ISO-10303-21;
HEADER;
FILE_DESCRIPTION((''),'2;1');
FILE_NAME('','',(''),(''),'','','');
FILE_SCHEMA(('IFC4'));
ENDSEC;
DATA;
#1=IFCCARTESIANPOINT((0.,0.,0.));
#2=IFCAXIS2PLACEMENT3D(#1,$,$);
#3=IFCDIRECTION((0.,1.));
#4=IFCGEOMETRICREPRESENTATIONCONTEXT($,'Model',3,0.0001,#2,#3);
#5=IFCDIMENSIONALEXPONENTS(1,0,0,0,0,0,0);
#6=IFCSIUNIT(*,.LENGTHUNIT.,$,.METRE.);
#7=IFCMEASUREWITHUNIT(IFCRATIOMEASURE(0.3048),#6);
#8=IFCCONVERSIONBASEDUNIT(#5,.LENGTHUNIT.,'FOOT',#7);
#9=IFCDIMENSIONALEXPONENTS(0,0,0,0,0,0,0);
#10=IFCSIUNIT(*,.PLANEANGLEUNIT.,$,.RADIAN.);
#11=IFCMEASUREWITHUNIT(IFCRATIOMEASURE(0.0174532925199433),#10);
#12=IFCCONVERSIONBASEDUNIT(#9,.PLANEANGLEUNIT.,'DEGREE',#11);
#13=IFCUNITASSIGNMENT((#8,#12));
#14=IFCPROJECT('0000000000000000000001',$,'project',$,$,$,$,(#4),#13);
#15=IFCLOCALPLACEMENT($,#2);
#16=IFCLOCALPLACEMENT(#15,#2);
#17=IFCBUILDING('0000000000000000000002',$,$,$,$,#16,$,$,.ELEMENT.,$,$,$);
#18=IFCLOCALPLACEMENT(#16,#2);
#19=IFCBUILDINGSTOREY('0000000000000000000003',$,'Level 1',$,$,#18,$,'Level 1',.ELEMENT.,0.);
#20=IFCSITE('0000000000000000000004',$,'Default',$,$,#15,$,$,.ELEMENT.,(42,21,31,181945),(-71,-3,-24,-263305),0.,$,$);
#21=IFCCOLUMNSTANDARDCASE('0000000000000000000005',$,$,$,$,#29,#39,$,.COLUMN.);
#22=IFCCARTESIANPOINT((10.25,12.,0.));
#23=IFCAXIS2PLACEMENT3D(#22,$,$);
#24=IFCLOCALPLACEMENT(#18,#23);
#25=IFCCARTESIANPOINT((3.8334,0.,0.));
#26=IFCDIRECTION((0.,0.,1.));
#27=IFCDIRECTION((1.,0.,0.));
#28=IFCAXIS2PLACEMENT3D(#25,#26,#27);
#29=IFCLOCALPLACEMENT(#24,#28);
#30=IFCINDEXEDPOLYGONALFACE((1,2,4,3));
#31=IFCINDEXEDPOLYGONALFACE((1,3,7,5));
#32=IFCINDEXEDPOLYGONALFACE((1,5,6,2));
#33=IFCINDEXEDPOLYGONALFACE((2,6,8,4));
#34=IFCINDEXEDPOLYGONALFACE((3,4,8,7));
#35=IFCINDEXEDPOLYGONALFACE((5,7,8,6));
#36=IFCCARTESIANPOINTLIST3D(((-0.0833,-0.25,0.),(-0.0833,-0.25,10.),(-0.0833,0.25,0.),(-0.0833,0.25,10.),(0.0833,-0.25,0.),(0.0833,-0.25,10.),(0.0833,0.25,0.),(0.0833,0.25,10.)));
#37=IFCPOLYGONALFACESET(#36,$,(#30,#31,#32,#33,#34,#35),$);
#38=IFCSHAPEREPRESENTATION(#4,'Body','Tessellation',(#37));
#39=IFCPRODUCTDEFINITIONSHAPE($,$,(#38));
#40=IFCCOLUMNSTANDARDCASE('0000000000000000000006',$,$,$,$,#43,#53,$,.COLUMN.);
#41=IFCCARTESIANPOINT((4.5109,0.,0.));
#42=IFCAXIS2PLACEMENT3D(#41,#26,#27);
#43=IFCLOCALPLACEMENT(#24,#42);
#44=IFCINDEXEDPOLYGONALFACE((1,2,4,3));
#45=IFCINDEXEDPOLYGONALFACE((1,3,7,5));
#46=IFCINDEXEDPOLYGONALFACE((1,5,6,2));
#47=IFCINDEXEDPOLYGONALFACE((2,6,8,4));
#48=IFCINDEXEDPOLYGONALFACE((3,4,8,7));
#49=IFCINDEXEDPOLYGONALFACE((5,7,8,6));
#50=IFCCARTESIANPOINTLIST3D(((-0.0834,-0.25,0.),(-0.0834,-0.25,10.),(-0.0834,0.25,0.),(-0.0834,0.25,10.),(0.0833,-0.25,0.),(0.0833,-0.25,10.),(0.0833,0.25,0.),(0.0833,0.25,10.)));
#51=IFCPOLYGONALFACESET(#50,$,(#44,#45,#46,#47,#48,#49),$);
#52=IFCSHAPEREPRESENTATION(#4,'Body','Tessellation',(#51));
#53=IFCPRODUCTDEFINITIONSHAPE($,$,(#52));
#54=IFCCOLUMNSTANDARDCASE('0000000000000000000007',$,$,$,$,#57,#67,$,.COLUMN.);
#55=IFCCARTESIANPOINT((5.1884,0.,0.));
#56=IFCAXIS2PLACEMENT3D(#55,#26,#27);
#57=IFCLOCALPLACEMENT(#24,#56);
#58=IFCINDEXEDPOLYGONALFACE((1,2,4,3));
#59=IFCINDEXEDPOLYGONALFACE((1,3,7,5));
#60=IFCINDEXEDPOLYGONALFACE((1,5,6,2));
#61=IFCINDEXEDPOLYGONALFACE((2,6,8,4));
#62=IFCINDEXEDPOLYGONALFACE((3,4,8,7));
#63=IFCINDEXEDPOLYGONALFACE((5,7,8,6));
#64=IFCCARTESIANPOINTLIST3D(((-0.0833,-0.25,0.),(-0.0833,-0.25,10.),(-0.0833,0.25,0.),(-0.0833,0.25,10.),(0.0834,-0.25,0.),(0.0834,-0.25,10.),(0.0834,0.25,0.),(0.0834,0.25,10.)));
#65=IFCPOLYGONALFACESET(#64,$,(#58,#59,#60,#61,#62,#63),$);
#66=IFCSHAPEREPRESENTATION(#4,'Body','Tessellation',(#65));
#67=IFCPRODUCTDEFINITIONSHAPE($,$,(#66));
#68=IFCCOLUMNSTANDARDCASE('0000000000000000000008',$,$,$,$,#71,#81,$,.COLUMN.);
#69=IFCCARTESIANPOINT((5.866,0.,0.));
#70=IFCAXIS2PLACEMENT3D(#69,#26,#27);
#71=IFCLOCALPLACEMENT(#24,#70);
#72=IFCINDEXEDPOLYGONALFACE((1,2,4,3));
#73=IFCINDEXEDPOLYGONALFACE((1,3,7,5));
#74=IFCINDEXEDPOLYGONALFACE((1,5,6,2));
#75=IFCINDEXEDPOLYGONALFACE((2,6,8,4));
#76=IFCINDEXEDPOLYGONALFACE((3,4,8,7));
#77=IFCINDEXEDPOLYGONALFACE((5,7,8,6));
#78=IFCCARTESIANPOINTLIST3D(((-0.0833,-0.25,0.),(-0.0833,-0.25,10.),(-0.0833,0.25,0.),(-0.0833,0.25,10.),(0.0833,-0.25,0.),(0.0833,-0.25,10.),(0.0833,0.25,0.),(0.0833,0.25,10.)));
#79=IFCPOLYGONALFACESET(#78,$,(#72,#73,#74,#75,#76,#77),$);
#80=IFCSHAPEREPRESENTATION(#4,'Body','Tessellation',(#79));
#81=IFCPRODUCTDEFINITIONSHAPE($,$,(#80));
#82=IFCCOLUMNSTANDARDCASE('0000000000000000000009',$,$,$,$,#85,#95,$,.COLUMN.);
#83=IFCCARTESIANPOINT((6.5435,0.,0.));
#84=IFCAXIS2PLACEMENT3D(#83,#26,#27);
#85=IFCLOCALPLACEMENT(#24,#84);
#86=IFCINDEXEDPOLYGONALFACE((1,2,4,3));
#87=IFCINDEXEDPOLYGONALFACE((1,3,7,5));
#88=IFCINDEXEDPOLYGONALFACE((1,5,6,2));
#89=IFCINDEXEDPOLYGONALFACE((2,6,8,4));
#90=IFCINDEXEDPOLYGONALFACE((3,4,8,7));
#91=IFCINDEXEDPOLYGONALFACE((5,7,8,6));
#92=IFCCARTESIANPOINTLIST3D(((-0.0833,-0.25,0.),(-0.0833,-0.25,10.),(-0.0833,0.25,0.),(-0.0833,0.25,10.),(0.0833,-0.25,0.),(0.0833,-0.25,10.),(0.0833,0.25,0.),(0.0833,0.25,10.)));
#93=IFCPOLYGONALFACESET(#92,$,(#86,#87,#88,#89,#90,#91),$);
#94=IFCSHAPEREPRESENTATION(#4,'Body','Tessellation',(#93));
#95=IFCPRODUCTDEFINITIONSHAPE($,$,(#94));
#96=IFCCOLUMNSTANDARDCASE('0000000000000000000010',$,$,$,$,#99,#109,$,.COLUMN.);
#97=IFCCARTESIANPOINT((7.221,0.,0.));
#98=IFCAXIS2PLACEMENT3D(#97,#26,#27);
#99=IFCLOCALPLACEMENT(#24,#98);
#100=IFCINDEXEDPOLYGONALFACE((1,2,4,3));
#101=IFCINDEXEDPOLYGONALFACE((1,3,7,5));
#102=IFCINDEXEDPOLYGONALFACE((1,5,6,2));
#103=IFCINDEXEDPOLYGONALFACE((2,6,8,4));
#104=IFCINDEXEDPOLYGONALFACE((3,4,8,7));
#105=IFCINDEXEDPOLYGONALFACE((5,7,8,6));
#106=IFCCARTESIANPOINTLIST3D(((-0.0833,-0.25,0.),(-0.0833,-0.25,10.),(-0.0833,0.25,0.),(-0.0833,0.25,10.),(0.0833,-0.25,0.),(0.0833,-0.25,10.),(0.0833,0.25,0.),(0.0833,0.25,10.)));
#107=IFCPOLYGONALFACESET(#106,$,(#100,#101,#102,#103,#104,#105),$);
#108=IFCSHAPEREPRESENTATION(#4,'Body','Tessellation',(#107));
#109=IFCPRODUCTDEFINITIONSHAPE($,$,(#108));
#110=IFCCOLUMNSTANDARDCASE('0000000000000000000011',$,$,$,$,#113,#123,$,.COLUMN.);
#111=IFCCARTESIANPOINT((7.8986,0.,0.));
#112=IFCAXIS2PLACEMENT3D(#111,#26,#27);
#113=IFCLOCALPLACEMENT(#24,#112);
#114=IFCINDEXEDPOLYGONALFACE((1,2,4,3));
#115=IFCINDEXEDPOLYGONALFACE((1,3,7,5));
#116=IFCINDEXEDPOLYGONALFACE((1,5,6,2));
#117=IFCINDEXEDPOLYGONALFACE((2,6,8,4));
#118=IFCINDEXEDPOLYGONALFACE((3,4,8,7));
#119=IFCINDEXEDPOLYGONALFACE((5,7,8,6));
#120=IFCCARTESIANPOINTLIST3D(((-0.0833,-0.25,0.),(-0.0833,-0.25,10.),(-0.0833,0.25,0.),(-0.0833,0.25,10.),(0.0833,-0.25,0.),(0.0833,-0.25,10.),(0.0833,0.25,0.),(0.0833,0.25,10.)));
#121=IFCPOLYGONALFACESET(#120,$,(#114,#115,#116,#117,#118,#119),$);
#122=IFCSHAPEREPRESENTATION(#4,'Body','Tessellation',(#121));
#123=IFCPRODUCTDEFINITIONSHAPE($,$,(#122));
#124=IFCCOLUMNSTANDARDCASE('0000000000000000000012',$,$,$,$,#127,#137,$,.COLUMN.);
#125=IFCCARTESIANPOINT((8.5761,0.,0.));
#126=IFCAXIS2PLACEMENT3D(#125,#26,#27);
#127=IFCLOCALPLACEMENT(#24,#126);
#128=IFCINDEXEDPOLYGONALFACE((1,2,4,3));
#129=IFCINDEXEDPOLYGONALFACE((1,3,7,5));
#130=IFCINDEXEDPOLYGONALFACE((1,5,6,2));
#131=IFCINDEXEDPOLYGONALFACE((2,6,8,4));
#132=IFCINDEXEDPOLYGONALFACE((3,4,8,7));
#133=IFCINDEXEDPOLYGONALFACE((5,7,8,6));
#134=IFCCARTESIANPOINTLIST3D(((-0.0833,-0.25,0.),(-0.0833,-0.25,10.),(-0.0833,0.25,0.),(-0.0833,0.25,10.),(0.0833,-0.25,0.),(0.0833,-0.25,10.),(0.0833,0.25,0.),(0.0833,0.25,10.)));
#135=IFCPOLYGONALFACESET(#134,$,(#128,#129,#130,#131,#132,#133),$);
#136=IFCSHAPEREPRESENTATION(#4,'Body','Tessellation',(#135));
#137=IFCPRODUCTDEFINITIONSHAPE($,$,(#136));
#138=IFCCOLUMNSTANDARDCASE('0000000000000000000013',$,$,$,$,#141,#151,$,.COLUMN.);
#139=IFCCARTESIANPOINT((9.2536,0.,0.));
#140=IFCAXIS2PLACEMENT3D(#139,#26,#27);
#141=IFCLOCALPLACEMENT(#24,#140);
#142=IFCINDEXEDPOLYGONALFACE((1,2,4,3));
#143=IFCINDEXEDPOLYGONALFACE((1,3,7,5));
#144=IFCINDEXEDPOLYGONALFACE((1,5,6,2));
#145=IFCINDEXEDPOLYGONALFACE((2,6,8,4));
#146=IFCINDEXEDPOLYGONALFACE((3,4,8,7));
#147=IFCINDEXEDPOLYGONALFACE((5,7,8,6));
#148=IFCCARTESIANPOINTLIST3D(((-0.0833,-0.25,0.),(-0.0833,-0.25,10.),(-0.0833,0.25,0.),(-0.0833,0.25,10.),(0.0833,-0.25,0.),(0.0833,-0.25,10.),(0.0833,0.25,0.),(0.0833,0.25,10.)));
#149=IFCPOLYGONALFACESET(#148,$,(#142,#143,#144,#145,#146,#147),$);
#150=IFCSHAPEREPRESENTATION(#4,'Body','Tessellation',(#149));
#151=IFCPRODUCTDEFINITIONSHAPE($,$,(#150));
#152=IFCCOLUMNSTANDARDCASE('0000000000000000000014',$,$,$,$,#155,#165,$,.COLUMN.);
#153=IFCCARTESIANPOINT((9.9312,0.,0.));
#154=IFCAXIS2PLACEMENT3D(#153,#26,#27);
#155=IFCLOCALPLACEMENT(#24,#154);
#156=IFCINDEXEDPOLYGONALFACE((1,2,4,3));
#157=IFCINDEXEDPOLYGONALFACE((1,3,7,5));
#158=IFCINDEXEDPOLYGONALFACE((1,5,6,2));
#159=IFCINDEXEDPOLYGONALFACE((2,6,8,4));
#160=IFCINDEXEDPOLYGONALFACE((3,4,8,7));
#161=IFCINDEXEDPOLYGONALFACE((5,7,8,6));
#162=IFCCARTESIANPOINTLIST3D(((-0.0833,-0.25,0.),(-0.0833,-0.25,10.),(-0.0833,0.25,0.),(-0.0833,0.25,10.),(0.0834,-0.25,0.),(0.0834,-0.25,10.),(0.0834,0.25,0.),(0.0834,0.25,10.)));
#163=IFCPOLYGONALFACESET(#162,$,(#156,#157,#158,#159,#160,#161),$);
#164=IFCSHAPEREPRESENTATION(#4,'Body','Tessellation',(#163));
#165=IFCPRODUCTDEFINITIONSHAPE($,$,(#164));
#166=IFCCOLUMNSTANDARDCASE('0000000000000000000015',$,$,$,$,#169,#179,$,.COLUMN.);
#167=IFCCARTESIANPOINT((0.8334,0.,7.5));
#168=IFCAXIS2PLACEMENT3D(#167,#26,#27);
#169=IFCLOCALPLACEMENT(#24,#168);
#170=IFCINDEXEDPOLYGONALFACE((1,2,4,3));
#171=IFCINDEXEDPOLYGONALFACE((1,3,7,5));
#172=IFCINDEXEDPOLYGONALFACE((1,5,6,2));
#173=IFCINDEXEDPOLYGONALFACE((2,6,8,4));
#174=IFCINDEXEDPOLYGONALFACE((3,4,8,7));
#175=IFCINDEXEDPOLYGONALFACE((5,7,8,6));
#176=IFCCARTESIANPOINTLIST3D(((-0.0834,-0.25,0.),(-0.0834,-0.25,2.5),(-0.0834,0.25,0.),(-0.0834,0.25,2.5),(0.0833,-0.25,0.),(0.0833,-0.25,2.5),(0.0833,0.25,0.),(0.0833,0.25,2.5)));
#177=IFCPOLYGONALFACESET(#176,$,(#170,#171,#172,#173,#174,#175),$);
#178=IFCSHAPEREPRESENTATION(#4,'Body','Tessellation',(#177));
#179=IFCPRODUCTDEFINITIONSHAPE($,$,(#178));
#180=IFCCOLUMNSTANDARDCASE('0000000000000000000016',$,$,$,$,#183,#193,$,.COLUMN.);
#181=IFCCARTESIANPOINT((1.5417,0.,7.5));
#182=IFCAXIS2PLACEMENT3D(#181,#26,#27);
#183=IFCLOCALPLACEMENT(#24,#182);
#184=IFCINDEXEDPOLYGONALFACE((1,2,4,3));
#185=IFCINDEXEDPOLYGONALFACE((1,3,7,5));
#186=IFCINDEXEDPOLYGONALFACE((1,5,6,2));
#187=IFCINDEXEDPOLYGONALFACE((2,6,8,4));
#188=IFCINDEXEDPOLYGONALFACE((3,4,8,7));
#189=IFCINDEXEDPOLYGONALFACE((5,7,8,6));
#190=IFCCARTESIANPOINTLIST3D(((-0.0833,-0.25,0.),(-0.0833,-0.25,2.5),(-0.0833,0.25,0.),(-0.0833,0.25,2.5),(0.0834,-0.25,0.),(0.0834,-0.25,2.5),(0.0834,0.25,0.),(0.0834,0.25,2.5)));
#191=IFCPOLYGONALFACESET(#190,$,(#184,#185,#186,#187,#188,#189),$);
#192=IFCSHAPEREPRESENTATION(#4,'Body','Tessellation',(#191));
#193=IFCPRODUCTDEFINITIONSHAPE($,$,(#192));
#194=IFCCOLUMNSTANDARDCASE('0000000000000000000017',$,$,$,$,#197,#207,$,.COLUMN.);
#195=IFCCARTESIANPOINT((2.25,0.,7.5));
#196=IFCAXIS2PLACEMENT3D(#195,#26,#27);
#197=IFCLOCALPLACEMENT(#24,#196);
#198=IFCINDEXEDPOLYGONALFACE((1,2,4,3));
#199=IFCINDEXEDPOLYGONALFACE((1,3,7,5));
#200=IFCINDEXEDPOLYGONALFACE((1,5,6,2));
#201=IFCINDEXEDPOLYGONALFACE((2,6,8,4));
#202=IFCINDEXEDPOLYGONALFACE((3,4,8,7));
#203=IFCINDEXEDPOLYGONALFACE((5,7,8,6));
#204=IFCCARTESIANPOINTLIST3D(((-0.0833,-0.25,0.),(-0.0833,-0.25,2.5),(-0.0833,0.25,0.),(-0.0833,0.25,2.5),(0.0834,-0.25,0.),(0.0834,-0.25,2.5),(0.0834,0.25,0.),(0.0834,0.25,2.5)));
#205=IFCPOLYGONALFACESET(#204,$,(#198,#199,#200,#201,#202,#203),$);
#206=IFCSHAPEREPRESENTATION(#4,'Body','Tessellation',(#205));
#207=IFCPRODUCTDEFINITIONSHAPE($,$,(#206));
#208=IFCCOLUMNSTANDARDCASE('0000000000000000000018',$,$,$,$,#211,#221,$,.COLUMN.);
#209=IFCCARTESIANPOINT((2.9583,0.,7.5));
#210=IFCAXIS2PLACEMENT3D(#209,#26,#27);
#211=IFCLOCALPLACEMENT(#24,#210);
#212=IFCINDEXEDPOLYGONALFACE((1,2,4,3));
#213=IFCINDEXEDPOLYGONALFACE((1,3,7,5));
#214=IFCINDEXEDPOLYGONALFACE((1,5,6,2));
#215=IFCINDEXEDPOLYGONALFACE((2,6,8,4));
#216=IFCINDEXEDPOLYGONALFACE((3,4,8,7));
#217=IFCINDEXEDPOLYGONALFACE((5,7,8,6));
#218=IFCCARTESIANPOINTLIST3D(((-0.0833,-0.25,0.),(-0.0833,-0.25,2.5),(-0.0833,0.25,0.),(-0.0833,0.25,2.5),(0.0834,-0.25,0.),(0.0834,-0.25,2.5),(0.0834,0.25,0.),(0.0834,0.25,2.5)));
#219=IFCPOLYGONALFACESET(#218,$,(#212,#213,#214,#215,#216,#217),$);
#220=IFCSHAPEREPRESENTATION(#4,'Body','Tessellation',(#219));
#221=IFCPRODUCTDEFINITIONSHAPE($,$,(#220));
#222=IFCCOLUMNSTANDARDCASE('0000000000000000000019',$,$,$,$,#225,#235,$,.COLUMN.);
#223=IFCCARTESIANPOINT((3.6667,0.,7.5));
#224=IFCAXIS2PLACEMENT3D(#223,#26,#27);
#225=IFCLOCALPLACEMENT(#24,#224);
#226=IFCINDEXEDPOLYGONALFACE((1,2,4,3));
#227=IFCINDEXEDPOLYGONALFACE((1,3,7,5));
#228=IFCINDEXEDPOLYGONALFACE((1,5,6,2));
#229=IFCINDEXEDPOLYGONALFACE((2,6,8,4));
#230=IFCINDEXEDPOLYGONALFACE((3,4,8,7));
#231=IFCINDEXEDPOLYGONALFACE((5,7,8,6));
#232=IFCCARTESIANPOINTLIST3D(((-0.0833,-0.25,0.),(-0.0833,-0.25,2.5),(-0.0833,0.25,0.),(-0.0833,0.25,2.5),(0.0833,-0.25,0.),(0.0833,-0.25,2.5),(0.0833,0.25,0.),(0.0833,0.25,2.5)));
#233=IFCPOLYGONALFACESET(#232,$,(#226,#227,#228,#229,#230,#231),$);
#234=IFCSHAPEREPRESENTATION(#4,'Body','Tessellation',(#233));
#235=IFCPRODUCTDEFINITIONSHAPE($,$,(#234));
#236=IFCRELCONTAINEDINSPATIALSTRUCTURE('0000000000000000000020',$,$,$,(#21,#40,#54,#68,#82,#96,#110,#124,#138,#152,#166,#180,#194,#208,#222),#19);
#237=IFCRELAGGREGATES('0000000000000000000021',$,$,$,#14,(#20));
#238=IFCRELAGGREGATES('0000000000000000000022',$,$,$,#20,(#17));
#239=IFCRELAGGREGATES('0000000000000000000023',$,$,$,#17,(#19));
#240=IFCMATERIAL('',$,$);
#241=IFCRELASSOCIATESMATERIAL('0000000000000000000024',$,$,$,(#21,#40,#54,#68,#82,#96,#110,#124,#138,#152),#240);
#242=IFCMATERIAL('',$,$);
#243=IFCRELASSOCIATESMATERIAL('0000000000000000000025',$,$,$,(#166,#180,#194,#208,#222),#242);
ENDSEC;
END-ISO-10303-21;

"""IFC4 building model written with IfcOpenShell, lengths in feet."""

from ifc_helpers import new_model, entity, si_unit, converted_unit, direction, frame, origin, place, context, project, spatial, rectangle, extrude, material, element, save


model = new_model("IFC4")

# Units and contexts
model_context = context("Model", 3, precision=0.0001, world=origin(), true_north=direction((0.0, 1.0)))
ifc_project = project(units=[converted_unit("LENGTHUNIT", "FOOT", entity("IfcRatioMeasure", 0.3048), si_unit("LENGTHUNIT", "METRE"), dimensions=[1, 0, 0, 0, 0, 0, 0]), converted_unit("PLANEANGLEUNIT", "DEGREE", entity("IfcRatioMeasure", 0.0174532925199433), si_unit("PLANEANGLEUNIT", "RADIAN"), dimensions=[0, 0, 0, 0, 0, 0, 0])], contexts=[model_context])

# Site, building, storey
site_placement = place(None, origin())
site = spatial("IfcSite", under=ifc_project, at=site_placement, Name="Default", CompositionType="ELEMENT", RefLatitude=(42, 21, 31, 181945), RefLongitude=(-71, -3, -24, -263305), RefElevation=0.0)
building_placement = place(site_placement, origin())
building = spatial("IfcBuilding", under=site, at=building_placement, CompositionType="ELEMENT")
storey_placement = place(building_placement, origin())
storey = spatial("IfcBuildingStorey", under=building, at=storey_placement, Name="Level 1", LongName="Level 1", CompositionType="ELEMENT", Elevation=0.0)

# Columns
ifc_material_1 = material(Name="")
placement_1 = place(storey_placement, frame((10.25, 12.0, 0.0)))
for number, where, z_axis, x_axis in (
    (1, (3.8334, 0.0, 0.0), (0.0, 0.0, 1.0), (1.0, 0.0, 0.0)),
    (2, (4.5109, 0.0, 0.0), (0.0, 0.0, 1.0), (1.0, 0.0, 0.0)),
    (3, (5.1884, 0.0, 0.0), (0.0, 0.0, 1.0), (1.0, 0.0, 0.0)),
    (4, (5.866, 0.0, 0.0), (0.0, 0.0, 1.0), (1.0, 0.0, 0.0)),
    (5, (6.5435, 0.0, 0.0), (0.0, 0.0, 1.0), (1.0, 0.0, 0.0)),
    (6, (7.221, 0.0, 0.0), (0.0, 0.0, 1.0), (1.0, 0.0, 0.0)),
    (7, (7.8986, 0.0, 0.0), (0.0, 0.0, 1.0), (1.0, 0.0, 0.0)),
    (8, (8.5761, 0.0, 0.0), (0.0, 0.0, 1.0), (1.0, 0.0, 0.0)),
    (9, (9.2536, 0.0, 0.0), (0.0, 0.0, 1.0), (1.0, 0.0, 0.0)),
    (10, (9.9312, 0.0, 0.0), (0.0, 0.0, 1.0), (1.0, 0.0, 0.0)),
):
    element("IfcColumnStandardCase", number, at=place(placement_1, frame(where, z_axis=z_axis, x_axis=x_axis)), inside=storey, material=ifc_material_1, PredefinedType="COLUMN", context=model_context, shape_type="SweptSolid", body=[
        extrude(rectangle(XDim=0.1667, YDim=0.5), origin(), (0.0, 0.0, 1.0), 10.0),
    ])
ifc_material_2 = material(Name="")
for number, where, z_axis, x_axis in (
    (11, (0.8334, 0.0, 7.5), (0.0, 0.0, 1.0), (1.0, 0.0, 0.0)),
    (12, (1.5417, 0.0, 7.5), (0.0, 0.0, 1.0), (1.0, 0.0, 0.0)),
    (13, (2.25, 0.0, 7.5), (0.0, 0.0, 1.0), (1.0, 0.0, 0.0)),
    (14, (2.9583, 0.0, 7.5), (0.0, 0.0, 1.0), (1.0, 0.0, 0.0)),
    (15, (3.6667, 0.0, 7.5), (0.0, 0.0, 1.0), (1.0, 0.0, 0.0)),
):
    element("IfcColumnStandardCase", number, at=place(placement_1, frame(where, z_axis=z_axis, x_axis=x_axis)), inside=storey, material=ifc_material_2, PredefinedType="COLUMN", context=model_context, shape_type="SweptSolid", body=[
        extrude(rectangle(XDim=0.1667, YDim=0.5), origin(), (0.0, 0.0, 1.0), 2.5),
    ])

save(model, "model.ifc")
